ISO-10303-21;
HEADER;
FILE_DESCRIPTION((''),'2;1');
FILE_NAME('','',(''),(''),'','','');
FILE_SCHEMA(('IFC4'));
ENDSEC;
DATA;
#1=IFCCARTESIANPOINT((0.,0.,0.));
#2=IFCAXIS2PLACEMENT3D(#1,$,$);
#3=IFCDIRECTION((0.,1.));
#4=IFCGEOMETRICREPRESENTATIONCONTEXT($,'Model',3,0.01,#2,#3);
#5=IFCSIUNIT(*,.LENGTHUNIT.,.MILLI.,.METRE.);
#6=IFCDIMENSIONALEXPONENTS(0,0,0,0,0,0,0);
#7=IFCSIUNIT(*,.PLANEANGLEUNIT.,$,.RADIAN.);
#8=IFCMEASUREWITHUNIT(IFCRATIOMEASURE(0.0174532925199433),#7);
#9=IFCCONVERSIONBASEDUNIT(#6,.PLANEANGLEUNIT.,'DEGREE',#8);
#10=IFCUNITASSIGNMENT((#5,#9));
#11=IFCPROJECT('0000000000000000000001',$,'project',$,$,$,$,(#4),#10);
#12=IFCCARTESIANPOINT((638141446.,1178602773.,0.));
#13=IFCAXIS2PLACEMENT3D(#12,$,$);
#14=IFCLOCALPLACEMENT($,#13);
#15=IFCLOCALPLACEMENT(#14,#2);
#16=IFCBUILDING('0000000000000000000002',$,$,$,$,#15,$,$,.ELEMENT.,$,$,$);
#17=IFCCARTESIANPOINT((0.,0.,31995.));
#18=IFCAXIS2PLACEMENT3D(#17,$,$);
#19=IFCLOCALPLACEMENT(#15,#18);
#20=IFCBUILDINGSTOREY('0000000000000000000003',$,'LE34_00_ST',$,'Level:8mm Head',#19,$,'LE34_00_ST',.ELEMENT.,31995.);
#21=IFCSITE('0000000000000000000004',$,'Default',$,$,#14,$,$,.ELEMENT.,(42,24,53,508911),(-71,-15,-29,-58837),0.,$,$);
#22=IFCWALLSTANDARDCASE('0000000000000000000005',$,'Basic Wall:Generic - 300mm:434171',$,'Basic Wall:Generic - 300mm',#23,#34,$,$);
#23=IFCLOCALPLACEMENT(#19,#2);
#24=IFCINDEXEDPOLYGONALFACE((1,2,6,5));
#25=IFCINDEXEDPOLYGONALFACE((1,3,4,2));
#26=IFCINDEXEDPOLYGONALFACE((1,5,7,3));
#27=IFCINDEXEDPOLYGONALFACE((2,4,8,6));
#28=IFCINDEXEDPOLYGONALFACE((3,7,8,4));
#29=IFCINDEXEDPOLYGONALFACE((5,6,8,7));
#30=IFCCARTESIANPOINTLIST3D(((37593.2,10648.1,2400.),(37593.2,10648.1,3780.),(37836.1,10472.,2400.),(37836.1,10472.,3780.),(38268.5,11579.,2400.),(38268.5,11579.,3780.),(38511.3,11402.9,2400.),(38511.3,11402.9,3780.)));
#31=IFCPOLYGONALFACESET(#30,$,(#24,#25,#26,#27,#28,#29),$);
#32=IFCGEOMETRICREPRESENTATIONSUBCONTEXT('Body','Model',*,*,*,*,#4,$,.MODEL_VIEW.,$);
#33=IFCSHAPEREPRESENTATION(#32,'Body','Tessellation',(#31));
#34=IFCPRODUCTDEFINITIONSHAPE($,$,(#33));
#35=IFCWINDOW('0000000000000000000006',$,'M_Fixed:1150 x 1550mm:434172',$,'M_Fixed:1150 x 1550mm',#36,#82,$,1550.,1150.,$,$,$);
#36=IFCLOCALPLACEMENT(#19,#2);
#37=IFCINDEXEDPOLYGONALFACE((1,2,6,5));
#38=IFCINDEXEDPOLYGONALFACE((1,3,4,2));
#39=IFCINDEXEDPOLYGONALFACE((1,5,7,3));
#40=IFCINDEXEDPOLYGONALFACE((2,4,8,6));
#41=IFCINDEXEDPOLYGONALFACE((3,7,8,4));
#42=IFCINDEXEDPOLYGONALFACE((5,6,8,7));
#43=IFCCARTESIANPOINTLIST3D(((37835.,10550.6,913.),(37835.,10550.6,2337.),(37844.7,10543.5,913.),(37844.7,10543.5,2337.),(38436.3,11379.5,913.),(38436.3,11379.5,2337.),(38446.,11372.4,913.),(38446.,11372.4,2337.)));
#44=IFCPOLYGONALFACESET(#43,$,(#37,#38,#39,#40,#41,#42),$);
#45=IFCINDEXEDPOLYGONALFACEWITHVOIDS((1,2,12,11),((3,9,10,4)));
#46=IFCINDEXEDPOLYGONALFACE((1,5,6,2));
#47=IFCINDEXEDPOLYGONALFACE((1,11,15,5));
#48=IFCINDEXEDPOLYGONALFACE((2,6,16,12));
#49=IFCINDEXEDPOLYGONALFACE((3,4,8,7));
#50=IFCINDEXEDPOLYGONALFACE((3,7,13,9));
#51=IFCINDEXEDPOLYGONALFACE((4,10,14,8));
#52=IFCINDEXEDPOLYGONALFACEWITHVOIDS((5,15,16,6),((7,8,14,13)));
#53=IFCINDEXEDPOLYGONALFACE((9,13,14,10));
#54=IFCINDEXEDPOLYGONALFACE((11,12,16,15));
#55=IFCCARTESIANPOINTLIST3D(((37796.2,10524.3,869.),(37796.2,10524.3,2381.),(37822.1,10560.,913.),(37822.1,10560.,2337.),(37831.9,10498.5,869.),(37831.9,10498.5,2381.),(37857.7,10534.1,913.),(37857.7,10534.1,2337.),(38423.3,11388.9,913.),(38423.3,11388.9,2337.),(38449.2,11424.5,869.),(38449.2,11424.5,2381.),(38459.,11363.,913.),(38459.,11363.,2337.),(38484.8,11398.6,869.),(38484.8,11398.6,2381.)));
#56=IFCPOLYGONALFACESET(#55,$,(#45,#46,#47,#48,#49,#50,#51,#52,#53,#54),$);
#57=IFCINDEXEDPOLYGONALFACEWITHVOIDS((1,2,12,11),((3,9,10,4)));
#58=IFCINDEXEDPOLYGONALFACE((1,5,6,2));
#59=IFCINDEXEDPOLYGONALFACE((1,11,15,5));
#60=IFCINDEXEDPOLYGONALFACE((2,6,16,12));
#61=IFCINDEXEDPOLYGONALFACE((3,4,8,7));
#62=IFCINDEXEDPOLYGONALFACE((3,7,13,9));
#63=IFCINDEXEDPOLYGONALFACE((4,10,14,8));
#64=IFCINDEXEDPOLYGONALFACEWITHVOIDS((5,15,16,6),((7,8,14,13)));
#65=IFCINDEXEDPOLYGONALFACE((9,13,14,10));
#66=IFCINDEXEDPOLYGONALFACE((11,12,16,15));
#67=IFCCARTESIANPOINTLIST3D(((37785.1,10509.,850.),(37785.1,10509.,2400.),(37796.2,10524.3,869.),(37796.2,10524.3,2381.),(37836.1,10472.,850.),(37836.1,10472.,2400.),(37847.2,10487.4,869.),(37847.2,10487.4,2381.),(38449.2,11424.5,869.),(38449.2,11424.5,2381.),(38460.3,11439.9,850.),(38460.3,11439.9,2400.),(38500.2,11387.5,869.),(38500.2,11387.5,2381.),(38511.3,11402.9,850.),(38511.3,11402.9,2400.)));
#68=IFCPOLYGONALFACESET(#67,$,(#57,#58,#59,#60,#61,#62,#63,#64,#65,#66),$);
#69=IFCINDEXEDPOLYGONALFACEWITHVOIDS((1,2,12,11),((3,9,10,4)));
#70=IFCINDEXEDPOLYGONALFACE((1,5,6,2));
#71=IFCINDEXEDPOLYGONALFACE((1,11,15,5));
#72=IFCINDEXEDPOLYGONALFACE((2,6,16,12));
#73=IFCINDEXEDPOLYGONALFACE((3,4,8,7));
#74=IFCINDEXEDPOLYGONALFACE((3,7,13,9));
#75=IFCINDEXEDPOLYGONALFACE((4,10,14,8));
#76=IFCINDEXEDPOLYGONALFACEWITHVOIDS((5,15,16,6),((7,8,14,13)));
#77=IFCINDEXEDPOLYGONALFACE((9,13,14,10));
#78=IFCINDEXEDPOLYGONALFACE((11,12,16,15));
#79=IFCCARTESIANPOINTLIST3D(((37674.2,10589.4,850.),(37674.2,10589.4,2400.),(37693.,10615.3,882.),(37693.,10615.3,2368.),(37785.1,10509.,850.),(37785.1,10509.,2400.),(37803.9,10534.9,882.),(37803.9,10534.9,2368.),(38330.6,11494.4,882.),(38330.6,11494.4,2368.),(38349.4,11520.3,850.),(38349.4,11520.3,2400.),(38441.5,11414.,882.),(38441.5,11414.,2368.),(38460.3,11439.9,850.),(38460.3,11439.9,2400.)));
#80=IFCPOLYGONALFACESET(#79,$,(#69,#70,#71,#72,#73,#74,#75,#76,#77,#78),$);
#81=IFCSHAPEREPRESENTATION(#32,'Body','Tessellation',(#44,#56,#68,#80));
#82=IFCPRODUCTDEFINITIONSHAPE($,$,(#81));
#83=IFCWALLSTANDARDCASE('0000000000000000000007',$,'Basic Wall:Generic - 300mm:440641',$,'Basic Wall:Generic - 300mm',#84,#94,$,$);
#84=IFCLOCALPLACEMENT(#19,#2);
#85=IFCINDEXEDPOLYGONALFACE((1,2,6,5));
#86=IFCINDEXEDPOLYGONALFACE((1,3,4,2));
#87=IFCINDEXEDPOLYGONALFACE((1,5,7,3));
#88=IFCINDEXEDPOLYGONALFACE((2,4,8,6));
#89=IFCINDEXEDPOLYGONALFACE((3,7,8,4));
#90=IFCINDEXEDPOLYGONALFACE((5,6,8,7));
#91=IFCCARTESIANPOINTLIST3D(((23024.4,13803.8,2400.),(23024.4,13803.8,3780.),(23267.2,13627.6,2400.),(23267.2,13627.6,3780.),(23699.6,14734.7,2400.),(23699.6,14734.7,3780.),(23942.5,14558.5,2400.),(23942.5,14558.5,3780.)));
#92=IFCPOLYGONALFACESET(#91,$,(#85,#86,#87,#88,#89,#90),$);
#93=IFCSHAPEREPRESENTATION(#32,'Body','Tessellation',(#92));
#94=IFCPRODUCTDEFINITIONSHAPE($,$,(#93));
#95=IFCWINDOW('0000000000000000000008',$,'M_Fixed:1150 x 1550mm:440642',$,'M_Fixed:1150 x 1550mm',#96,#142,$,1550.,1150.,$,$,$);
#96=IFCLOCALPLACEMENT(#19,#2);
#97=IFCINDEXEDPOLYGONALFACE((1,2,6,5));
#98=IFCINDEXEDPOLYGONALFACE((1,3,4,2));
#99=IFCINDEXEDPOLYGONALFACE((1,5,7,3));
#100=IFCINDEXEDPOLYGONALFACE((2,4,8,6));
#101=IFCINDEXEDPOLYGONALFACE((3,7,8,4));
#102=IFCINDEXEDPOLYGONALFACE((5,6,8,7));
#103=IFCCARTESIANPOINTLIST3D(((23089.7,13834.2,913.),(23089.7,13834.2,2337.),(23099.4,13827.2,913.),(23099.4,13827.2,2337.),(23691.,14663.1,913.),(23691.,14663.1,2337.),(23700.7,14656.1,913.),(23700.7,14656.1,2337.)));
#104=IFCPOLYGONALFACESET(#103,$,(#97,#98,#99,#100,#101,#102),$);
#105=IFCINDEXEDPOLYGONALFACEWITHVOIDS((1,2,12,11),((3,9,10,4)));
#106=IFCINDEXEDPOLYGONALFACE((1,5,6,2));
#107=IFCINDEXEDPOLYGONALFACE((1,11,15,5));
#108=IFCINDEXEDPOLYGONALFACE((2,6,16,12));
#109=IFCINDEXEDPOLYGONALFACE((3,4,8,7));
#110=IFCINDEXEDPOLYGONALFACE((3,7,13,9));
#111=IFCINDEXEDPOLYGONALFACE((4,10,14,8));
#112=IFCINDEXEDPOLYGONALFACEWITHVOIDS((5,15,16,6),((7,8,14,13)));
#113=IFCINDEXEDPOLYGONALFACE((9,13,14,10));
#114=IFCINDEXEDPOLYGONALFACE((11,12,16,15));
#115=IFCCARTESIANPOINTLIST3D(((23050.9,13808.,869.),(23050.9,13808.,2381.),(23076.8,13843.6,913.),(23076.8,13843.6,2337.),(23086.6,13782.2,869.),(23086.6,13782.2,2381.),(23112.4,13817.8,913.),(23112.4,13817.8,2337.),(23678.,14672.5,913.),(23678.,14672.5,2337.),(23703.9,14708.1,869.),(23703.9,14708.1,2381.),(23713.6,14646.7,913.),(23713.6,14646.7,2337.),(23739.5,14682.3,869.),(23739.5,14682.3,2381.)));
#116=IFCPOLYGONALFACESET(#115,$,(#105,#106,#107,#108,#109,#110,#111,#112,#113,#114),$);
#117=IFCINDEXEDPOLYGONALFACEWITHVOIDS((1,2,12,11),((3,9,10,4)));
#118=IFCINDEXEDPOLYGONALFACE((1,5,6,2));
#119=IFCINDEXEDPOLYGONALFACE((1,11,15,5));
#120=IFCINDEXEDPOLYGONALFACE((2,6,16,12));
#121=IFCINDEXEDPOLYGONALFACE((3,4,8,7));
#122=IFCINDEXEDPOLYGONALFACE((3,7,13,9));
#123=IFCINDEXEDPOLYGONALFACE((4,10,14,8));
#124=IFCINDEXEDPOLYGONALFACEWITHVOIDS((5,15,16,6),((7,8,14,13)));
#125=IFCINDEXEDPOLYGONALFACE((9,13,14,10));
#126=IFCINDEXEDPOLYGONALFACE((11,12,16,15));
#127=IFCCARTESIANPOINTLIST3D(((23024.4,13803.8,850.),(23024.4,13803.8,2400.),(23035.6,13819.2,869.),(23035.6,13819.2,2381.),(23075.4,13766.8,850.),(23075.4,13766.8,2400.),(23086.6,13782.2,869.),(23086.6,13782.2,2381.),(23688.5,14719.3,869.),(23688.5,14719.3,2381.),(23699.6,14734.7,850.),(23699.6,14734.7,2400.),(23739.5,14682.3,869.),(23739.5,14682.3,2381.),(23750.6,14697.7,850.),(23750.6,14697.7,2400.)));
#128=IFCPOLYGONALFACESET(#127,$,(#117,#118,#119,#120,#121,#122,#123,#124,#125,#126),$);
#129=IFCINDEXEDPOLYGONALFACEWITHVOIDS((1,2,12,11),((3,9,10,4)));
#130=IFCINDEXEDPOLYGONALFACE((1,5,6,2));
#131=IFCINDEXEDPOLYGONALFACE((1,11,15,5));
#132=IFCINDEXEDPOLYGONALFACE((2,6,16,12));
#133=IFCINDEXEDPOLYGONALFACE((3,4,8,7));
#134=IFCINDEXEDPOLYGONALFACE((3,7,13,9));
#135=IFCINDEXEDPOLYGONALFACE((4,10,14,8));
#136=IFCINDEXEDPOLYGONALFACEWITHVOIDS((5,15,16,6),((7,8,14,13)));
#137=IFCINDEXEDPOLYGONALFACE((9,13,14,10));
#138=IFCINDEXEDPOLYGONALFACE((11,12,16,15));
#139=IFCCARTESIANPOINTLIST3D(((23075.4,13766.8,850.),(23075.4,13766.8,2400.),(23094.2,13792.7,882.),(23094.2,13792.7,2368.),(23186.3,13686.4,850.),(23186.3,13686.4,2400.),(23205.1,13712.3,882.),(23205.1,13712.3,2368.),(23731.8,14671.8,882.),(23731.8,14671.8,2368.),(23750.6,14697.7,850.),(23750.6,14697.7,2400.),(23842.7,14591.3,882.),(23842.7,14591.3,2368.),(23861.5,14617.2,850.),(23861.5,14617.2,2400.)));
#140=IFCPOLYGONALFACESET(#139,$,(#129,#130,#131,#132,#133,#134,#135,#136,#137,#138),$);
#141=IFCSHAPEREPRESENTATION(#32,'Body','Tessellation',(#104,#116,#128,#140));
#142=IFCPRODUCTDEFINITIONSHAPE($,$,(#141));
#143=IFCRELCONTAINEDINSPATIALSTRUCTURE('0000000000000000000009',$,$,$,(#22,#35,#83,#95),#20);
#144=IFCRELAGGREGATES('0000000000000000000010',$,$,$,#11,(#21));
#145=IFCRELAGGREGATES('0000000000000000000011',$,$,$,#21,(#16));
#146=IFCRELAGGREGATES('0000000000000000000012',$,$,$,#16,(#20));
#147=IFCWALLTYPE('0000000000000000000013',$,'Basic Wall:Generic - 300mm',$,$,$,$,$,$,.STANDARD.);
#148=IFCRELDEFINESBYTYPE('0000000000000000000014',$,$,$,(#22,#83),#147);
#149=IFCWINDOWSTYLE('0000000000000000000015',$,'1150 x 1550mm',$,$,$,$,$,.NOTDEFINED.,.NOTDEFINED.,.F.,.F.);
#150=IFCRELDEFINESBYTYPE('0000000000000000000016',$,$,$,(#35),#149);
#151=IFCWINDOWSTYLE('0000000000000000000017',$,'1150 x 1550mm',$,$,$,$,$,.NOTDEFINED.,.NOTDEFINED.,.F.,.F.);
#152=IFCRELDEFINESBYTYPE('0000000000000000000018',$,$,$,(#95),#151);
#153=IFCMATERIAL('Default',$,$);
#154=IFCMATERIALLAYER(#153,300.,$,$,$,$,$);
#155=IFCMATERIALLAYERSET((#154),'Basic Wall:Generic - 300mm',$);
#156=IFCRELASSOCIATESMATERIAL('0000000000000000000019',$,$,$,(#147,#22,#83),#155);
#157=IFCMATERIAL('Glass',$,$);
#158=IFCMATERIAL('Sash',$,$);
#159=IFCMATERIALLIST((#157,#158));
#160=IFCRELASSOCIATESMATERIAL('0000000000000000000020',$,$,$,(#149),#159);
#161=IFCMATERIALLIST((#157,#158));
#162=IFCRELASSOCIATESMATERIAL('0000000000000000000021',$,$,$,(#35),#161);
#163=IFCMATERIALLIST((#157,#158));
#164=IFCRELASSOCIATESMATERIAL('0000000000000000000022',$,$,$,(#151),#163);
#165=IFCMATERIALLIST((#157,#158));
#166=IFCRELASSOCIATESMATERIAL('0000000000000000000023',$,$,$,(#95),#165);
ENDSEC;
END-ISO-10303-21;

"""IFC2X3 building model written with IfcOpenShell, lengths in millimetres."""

from ifc_helpers import new_model, entity, si_unit, converted_unit, direction, frame, frame_2d, origin, place, context, subcontext, project, spatial, polyline, rectangle, outline, extrude, source, transform, mapped, material, material_list, layer, layer_set, layer_usage, type_object, type_shapes, element, fill, save


model = new_model("IFC2X3")

# Units and contexts
model_context = context("Model", 3, precision=0.01, world=origin(), true_north=direction((0.0, 1.0)))
body_context = subcontext(model_context, "Body", "Model", "MODEL_VIEW")
ifc_project = project(units=[si_unit("LENGTHUNIT", "METRE", prefix="MILLI"), converted_unit("PLANEANGLEUNIT", "DEGREE", entity("IfcRatioMeasure", 0.0174532925199433), si_unit("PLANEANGLEUNIT", "RADIAN"), dimensions=[0, 0, 0, 0, 0, 0, 0])], contexts=[model_context])

# Site, building, storey
site_placement = place(None, frame((638141446.0, 1178602773.0, 0.0)))
site = spatial("IfcSite", under=ifc_project, at=site_placement, Name="Default", CompositionType="ELEMENT", RefLatitude=(42, 24, 53, 508911), RefLongitude=(-71, -15, -29, -58837), RefElevation=0.0)
building_placement = place(site_placement, origin())
building = spatial("IfcBuilding", under=site, at=building_placement, CompositionType="ELEMENT")
storey_placement = place(building_placement, frame((0.0, 0.0, 31995.0)))
storey = spatial("IfcBuildingStorey", under=building, at=storey_placement, Name="LE34_00_ST", ObjectType="Level:8mm Head", LongName="LE34_00_ST", CompositionType="ELEMENT", Elevation=31995.0)

# Walls, openings, windows
ifc_material_1 = material(Name="Default")
ifc_layer_1 = layer(ifc_material_1, 300.0)
ifc_layer_set_1 = layer_set([ifc_layer_1], Name="Basic Wall:Generic - 300mm")
wall_type_1 = type_object("IfcWallType", Name="Basic Wall:Generic - 300mm", PredefinedType="STANDARD", material=ifc_layer_set_1)
ifc_material_2 = material(Name="Glass")
ifc_material_3 = material(Name="Sash")
ifc_material_list_1 = material_list([ifc_material_2, ifc_material_3])
window_style_1 = type_object("IfcWindowStyle", Name="1150 x 1550mm", ConstructionType="NOTDEFINED", OperationType="NOTDEFINED", ParameterTakesPrecedence=False, Sizeable=False, material=ifc_material_list_1)
shared_shape_1 = source(origin(), body_context, "Body", "SweptSolid", [
    extrude(rectangle(XDim=1024.0, YDim=12.0, at=frame_2d((0.0, 0.0), x_axis=(1.0, 0.0))), frame((575.0, 285.0, 63.0), z_axis=(0.0, 0.0, 1.0), x_axis=(-1.0, 0.0, 0.0)), (0.0, 0.0, 1.0), 1424.0),
    extrude(outline(polyline([(-556.0, -756.0), (556.0, -756.0), (556.0, 756.0), (-556.0, 756.0), (-556.0, -756.0)]), holes=[polyline([(-512.0, -712.0), (-512.0, 712.0), (512.0, 712.0), (512.0, -712.0), (-512.0, -712.0)])]), frame((575.0, 307.0, 775.0), z_axis=(0.0, -1.0, 0.0), x_axis=(-1.0, 0.0, 0.0)), (0.0, 0.0, 1.0), 44.0),
    extrude(outline(polyline([(-575.0, -775.0), (575.0, -775.0), (575.0, 775.0), (-575.0, 775.0), (-575.0, -775.0)]), holes=[polyline([(-556.0, -756.0), (-556.0, 756.0), (556.0, 756.0), (556.0, -756.0), (-556.0, -756.0)])]), frame((575.0, 326.0, 775.0), z_axis=(0.0, -1.0, 0.0), x_axis=(-1.0, 0.0, 0.0)), (0.0, 0.0, 1.0), 63.0),
    extrude(outline(polyline([(-575.0, -775.0), (575.0, -775.0), (575.0, 775.0), (-575.0, 775.0), (-575.0, -775.0)]), holes=[polyline([(-543.0, -743.0), (-543.0, 743.0), (543.0, 743.0), (543.0, -743.0), (-543.0, -743.0)])]), frame((575.0, 263.0, 775.0), z_axis=(0.0, -1.0, 0.0), x_axis=(-1.0, 0.0, 0.0)), (0.0, 0.0, 1.0), 137.0),
])
type_shapes(window_style_1, [shared_shape_1])
ifc_layer_usage_1 = layer_usage(ifc_layer_set_1, "AXIS2", "POSITIVE", -150.0)
wall_1_placement = place(storey_placement, frame((37714.7, 10560.1, 2400.0), z_axis=(0.0, 0.0, 1.0), x_axis=(0.587164, 0.809468, 0.0)))
wall_1 = element("IfcWallStandardCase", 1, at=wall_1_placement, inside=storey, type_object=wall_type_1, material=ifc_layer_usage_1, Name="Basic Wall:Generic - 300mm:434171", ObjectType="Basic Wall:Generic - 300mm", context=body_context, shape_type="SweptSolid", body=[
    extrude(rectangle(XDim=1150.0, YDim=300.0, at=frame_2d((575.0, 0.0), x_axis=(-1.0, 0.0))), origin(), (0.0, 0.0, 1.0), 1380.0),
])
opening_1_placement = place(wall_1_placement, frame((1150.0, 150.0, -1550.0)))
opening_1 = element("IfcOpeningElement", 2, at=opening_1_placement, cuts=wall_1, ObjectType="Opening", context=body_context, shape_type="SweptSolid", body=[
    extrude(rectangle(XDim=1550.0, YDim=1150.0, at=frame_2d((775.0, 575.0), x_axis=(1.0, 0.0))), frame((0.0, 0.0, 0.0), z_axis=(0.0, -1.0, 0.0), x_axis=(0.0, 0.0, 1.0)), (0.0, 0.0, 1.0), 300.0),
])
ifc_material_list_2 = material_list([ifc_material_2, ifc_material_3])
window_1_placement = place(opening_1_placement, frame((0.0, 26.0, 0.0), z_axis=(0.0, 0.0, 1.0), x_axis=(-1.0, 0.0, 0.0)))
window_1 = element("IfcWindow", 3, at=window_1_placement, inside=storey, type_object=window_style_1, material=ifc_material_list_2, Name="M_Fixed:1150 x 1550mm:434172", ObjectType="M_Fixed:1150 x 1550mm", OverallHeight=1550.0, OverallWidth=1150.0, context=body_context, shape_type="MappedRepresentation", body=[
    mapped(shared_shape_1, transform((0.0, 0.0, 0.0), scale=1.0)),
])
fill(opening_1, window_1)
ifc_material_list_3 = material_list([ifc_material_2, ifc_material_3])
window_style_2 = type_object("IfcWindowStyle", Name="1150 x 1550mm", ConstructionType="NOTDEFINED", OperationType="NOTDEFINED", ParameterTakesPrecedence=False, Sizeable=False, material=ifc_material_list_3)
shared_shape_2 = source(origin(), body_context, "Body", "SweptSolid", [
    extrude(rectangle(XDim=12.0, YDim=1024.0, at=frame_2d((0.0, 0.0), x_axis=(1.0, 0.0))), frame((575.0, 259.0, 63.0), z_axis=(0.0, 0.0, 1.0), x_axis=(0.0, -1.0, 0.0)), (0.0, 0.0, 1.0), 1424.0),
    extrude(outline(polyline([(-556.0, -756.0), (556.0, -756.0), (556.0, 756.0), (-556.0, 756.0), (-556.0, -756.0)]), holes=[polyline([(-512.0, -712.0), (-512.0, 712.0), (512.0, 712.0), (512.0, -712.0), (-512.0, -712.0)])]), frame((575.0, 237.0, 775.0), z_axis=(0.0, 1.0, 0.0), x_axis=(1.0, 0.0, 0.0)), (0.0, 0.0, 1.0), 44.0),
    extrude(outline(polyline([(-575.0, -775.0), (575.0, -775.0), (575.0, 775.0), (-575.0, 775.0), (-575.0, -775.0)]), holes=[polyline([(-556.0, -756.0), (-556.0, 756.0), (556.0, 756.0), (556.0, -756.0), (-556.0, -756.0)])]), frame((575.0, 237.0, 775.0), z_axis=(0.0, 1.0, 0.0), x_axis=(1.0, 0.0, 0.0)), (0.0, 0.0, 1.0), 63.0),
    extrude(outline(polyline([(-575.0, -775.0), (575.0, -775.0), (575.0, 775.0), (-575.0, 775.0), (-575.0, -775.0)]), holes=[polyline([(-543.0, -743.0), (-543.0, 743.0), (543.0, 743.0), (543.0, -743.0), (-543.0, -743.0)])]), frame((575.0, 100.0, 775.0), z_axis=(0.0, 1.0, 0.0), x_axis=(1.0, 0.0, 0.0)), (0.0, 0.0, 1.0), 137.0),
])
type_shapes(window_style_2, [shared_shape_2])
ifc_layer_usage_2 = layer_usage(ifc_layer_set_1, "AXIS2", "NEGATIVE", 150.0)
wall_2_placement = place(storey_placement, frame((23145.8, 13715.7, 2400.0), z_axis=(0.0, 0.0, 1.0), x_axis=(0.587164, 0.809468, 0.0)))
wall_2 = element("IfcWallStandardCase", 4, at=wall_2_placement, inside=storey, type_object=wall_type_1, material=ifc_layer_usage_2, Name="Basic Wall:Generic - 300mm:440641", ObjectType="Basic Wall:Generic - 300mm", context=body_context, shape_type="SweptSolid", body=[
    extrude(rectangle(XDim=1150.0, YDim=300.0, at=frame_2d((575.0, 0.0), x_axis=(-1.0, 0.0))), origin(), (0.0, 0.0, 1.0), 1380.0),
])
opening_2_placement = place(wall_2_placement, frame((0.0, -150.0, -1550.0)))
opening_2 = element("IfcOpeningElement", 5, at=opening_2_placement, cuts=wall_2, ObjectType="Opening", context=body_context, shape_type="SweptSolid", body=[
    extrude(rectangle(XDim=1550.0, YDim=1150.0, at=frame_2d((775.0, 575.0), x_axis=(1.0, 0.0))), frame((0.0, 0.0, 0.0), z_axis=(0.0, 1.0, 0.0), x_axis=(0.0, 0.0, 1.0)), (0.0, 0.0, 1.0), 300.0),
])
ifc_material_list_4 = material_list([ifc_material_2, ifc_material_3])
window_2_placement = place(opening_2_placement, origin())
window_2 = element("IfcWindow", 6, at=window_2_placement, inside=storey, type_object=window_style_2, material=ifc_material_list_4, Name="M_Fixed:1150 x 1550mm:440642", ObjectType="M_Fixed:1150 x 1550mm", OverallHeight=1550.0, OverallWidth=1150.0, context=body_context, shape_type="MappedRepresentation", body=[
    mapped(shared_shape_2, transform((0.0, 0.0, 0.0), scale=1.0)),
])
fill(opening_2, window_2)

save(model, "model.ifc")
